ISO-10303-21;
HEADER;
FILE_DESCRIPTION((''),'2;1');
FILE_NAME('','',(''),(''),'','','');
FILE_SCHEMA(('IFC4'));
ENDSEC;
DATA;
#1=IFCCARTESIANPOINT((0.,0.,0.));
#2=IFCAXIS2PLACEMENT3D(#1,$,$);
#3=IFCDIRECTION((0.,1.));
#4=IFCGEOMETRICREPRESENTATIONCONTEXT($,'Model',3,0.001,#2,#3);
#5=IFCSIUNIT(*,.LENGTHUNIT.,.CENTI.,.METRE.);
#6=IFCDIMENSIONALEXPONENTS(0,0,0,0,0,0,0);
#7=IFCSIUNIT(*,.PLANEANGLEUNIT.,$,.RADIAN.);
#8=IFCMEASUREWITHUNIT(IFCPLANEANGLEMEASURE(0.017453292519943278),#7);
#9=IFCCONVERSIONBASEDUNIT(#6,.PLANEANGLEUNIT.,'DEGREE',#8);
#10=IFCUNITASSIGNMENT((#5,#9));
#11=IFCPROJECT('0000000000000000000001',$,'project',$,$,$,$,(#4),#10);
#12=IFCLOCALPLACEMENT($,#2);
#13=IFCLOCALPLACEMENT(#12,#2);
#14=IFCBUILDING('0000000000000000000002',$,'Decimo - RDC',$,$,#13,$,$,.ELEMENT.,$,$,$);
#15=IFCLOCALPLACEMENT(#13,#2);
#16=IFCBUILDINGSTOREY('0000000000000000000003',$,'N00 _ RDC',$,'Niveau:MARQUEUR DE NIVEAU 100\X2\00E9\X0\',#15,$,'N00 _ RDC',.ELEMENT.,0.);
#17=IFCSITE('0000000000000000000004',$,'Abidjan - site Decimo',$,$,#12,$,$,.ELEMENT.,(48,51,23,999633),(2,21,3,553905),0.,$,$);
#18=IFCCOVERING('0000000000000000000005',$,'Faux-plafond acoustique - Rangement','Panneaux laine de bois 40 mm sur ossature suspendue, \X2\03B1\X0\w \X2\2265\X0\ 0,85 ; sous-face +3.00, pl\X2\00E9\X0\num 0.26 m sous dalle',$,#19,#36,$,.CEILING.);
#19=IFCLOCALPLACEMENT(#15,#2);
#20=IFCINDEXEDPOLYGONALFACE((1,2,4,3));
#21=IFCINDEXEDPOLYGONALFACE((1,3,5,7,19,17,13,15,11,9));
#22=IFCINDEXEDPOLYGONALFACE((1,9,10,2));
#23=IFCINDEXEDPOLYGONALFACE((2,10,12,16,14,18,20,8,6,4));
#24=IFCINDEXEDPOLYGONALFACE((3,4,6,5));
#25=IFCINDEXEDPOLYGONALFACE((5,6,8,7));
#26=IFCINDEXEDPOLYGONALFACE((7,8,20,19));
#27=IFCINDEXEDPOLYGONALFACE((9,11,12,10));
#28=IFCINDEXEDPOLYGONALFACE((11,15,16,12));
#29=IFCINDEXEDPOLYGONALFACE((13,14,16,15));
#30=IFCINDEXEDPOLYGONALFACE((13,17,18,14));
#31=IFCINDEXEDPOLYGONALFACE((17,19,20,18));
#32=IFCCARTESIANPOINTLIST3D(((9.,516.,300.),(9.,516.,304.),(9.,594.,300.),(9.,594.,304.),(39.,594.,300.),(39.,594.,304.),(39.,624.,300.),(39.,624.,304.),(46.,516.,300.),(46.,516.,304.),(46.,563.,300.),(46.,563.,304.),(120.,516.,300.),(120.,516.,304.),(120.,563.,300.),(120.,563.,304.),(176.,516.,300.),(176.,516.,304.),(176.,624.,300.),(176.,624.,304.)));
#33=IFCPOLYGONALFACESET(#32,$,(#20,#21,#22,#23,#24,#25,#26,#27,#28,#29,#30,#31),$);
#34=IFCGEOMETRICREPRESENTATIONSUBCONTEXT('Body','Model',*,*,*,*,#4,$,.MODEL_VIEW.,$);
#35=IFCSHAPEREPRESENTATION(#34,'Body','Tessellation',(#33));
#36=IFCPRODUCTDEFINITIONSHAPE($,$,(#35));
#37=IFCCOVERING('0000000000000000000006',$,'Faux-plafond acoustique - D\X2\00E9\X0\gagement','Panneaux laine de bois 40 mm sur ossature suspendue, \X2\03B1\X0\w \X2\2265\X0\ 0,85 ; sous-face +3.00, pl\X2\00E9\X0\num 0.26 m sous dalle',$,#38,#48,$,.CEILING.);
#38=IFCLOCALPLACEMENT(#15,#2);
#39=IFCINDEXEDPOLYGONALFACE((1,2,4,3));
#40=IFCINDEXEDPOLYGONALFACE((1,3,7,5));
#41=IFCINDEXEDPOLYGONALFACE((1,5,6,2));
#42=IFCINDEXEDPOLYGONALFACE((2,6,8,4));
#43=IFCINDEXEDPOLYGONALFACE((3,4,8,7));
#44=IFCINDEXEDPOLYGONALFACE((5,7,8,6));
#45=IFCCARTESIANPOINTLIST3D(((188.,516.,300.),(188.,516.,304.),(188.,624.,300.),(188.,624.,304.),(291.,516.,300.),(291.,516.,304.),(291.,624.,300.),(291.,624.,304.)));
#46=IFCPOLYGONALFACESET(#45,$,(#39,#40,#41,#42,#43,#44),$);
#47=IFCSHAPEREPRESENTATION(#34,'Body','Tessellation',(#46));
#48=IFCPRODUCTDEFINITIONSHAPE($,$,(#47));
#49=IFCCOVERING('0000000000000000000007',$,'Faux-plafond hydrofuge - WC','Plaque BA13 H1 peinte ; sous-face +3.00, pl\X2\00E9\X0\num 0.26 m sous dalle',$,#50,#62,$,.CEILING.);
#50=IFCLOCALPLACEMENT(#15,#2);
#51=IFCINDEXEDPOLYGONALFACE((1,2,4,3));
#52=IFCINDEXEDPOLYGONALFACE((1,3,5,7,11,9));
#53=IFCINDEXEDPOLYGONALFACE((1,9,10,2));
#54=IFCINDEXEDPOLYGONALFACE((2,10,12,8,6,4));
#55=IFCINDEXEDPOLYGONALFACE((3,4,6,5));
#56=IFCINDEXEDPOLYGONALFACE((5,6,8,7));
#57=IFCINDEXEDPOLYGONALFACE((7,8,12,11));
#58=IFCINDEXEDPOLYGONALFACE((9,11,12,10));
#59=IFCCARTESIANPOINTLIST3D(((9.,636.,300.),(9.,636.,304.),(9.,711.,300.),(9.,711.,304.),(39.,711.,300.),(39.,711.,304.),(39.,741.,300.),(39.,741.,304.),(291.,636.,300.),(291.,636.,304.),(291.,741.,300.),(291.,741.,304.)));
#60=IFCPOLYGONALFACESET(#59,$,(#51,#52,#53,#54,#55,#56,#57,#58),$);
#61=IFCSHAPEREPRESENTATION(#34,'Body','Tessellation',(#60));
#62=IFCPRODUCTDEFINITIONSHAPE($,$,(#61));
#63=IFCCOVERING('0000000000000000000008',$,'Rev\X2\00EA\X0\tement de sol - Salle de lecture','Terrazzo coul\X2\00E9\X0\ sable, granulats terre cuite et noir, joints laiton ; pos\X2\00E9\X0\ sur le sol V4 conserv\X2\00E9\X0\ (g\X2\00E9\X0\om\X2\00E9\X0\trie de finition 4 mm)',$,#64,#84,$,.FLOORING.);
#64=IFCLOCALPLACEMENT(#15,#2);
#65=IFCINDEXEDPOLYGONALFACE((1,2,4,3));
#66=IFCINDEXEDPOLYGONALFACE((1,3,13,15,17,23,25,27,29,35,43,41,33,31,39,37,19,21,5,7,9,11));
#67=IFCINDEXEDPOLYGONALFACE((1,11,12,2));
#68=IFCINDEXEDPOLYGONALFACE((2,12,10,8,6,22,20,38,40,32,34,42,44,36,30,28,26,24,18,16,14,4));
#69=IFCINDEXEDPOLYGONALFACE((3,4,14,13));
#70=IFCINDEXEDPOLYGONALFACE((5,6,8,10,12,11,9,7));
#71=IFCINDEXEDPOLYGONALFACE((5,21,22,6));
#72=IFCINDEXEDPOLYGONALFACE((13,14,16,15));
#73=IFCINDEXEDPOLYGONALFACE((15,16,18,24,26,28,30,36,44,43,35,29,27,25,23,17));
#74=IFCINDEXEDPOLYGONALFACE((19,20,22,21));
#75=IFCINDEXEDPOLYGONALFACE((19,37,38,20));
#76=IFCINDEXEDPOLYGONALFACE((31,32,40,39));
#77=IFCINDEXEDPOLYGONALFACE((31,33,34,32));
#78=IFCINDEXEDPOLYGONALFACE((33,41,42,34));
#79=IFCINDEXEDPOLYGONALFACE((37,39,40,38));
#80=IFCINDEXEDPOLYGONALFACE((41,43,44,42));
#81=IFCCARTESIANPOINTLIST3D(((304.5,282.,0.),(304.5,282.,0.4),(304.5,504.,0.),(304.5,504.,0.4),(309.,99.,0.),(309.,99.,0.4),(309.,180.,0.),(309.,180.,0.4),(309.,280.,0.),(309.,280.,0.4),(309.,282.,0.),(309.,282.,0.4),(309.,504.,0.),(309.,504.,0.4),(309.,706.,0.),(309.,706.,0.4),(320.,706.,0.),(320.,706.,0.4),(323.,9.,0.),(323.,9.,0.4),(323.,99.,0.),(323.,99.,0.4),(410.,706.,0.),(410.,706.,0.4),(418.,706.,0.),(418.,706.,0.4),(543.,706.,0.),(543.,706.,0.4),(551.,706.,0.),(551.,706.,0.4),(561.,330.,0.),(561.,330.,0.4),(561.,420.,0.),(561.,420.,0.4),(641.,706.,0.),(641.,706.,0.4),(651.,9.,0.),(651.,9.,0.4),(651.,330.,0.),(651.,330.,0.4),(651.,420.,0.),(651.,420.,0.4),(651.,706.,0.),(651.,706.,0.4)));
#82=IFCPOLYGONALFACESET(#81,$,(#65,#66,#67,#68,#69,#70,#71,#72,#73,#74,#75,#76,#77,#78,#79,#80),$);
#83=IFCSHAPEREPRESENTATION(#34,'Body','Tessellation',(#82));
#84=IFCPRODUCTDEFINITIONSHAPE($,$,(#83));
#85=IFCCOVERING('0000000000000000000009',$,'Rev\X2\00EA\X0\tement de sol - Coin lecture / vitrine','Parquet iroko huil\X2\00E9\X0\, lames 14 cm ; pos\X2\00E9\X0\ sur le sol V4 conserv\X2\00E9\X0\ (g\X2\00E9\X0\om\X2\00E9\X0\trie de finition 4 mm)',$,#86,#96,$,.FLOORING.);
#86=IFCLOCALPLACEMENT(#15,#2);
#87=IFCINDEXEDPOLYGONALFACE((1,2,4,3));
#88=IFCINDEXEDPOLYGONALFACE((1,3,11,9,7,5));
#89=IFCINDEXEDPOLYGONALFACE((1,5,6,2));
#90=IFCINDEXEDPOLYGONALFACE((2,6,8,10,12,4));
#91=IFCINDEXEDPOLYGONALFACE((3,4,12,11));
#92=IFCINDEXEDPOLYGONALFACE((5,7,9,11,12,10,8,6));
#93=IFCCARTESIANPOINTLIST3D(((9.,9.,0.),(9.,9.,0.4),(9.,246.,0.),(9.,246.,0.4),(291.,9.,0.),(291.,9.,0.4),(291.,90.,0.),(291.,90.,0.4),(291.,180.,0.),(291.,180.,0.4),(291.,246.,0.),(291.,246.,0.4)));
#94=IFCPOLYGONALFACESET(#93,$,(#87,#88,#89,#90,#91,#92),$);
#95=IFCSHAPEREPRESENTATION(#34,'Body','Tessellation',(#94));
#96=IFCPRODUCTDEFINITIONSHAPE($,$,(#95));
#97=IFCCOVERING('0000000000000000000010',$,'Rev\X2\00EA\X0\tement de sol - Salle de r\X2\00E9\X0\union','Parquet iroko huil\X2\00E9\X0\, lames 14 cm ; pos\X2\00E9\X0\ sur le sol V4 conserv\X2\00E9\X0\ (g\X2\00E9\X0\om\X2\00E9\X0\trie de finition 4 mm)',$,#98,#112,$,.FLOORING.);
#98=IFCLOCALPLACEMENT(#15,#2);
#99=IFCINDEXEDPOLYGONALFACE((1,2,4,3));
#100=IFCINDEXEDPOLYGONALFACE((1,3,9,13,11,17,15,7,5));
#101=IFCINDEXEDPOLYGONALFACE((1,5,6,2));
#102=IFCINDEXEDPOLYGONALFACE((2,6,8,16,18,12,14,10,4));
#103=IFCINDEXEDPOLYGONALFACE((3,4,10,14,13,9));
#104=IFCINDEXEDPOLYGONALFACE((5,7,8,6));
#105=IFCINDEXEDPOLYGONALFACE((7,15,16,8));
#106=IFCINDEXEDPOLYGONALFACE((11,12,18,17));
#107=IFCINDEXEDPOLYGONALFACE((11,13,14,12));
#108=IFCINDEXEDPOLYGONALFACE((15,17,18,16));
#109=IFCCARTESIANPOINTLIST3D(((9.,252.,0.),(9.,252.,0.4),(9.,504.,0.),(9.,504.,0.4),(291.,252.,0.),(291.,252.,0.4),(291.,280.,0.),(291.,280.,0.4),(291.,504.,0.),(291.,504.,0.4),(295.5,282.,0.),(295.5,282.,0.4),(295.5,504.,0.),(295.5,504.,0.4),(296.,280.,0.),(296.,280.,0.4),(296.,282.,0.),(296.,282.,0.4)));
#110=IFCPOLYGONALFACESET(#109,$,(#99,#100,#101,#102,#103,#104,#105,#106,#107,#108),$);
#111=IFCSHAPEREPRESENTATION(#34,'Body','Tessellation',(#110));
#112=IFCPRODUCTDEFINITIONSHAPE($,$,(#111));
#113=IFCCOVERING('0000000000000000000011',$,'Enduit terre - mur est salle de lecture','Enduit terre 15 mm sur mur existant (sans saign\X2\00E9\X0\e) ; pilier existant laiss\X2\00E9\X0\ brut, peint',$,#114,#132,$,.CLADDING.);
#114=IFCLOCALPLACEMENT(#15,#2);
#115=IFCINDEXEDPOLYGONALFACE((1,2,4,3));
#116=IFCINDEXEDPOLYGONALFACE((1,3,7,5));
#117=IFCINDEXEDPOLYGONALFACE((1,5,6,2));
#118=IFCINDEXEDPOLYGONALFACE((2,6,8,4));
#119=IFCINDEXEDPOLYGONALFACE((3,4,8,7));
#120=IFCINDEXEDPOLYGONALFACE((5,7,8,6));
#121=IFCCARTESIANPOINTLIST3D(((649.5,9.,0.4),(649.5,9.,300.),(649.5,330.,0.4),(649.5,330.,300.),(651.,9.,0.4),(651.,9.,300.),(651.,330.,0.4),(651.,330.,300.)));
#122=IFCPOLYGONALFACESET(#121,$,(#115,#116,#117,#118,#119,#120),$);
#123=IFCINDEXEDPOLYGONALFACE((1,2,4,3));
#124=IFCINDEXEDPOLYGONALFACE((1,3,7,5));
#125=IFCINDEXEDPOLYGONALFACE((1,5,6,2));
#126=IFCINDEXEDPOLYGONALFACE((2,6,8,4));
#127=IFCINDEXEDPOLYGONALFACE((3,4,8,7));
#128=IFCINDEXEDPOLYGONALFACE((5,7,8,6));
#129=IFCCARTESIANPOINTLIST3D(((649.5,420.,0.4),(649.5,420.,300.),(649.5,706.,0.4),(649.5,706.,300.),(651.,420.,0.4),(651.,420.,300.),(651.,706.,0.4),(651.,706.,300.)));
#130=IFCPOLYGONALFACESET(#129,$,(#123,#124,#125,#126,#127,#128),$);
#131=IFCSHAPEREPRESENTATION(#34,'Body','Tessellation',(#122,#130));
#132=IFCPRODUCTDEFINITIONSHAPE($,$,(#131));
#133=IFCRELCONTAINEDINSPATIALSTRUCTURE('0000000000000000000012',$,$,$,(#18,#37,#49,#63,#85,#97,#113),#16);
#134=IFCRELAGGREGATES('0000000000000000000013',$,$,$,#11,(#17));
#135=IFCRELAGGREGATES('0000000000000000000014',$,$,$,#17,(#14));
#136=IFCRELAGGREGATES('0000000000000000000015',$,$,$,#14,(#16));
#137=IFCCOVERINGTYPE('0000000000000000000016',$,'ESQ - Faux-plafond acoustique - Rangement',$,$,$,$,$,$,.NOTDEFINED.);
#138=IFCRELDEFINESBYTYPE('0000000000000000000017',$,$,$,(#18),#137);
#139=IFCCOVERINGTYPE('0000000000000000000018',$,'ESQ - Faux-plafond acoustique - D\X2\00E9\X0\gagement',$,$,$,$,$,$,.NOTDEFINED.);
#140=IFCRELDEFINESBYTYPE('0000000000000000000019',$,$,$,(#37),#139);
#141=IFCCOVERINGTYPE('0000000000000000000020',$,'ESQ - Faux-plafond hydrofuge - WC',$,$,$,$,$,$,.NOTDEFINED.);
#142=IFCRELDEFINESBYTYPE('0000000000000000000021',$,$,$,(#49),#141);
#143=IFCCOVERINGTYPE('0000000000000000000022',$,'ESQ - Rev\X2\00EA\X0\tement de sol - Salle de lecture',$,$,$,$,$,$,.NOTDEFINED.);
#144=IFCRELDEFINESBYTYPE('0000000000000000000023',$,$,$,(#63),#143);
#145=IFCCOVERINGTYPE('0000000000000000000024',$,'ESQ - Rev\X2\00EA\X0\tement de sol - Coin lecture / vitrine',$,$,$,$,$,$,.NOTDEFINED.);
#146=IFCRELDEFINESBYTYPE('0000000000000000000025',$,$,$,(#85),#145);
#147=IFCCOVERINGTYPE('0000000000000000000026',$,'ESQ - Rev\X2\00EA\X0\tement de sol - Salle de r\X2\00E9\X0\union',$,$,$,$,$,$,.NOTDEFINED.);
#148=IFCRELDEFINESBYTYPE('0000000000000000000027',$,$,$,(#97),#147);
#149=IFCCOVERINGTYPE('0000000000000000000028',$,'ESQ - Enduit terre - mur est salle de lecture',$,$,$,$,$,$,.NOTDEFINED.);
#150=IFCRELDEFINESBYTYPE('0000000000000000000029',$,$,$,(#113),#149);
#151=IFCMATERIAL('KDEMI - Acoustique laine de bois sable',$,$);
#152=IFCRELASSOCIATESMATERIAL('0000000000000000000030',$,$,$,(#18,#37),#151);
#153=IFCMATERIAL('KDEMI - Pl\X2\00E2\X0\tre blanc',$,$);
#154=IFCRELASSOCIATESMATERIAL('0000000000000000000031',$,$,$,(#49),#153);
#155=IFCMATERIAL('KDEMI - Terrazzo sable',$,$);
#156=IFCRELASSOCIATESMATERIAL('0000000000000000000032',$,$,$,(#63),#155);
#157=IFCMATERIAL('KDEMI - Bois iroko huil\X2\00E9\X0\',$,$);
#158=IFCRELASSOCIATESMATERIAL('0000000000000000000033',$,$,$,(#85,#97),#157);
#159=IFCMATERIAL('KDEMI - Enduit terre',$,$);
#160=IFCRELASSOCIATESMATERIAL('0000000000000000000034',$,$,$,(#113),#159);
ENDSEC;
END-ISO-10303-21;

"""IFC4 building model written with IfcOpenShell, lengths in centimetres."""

from ifc_helpers import new_model, entity, si_unit, converted_unit, direction, frame, frame_2d, origin, origin_with_axes, place, context, subcontext, project, spatial, polyline, rectangle, outline, extrude, material, type_object, element, save


model = new_model("IFC4")

# Units and contexts
model_context = context("Model", 3, precision=0.001, world=origin(), true_north=direction((0.0, 1.0)))
body_context = subcontext(model_context, "Body", "Model", "MODEL_VIEW")
ifc_project = project(units=[si_unit("LENGTHUNIT", "METRE", prefix="CENTI"), converted_unit("PLANEANGLEUNIT", "DEGREE", entity("IfcPlaneAngleMeasure", 0.017453292519943278), si_unit("PLANEANGLEUNIT", "RADIAN"), dimensions=[0, 0, 0, 0, 0, 0, 0])], contexts=[model_context])

# Site, building, storey
site_placement = place(None, origin())
site = spatial("IfcSite", under=ifc_project, at=site_placement, Name="Abidjan - site Decimo", CompositionType="ELEMENT", RefLatitude=(48, 51, 23, 999633), RefLongitude=(2, 21, 3, 553905), RefElevation=0.0)
building_placement = place(site_placement, origin())
building = spatial("IfcBuilding", under=site, at=building_placement, Name="Decimo - RDC", CompositionType="ELEMENT")
storey_placement = place(building_placement, origin())
storey = spatial("IfcBuildingStorey", under=building, at=storey_placement, Name="N00 _ RDC", ObjectType="Niveau:MARQUEUR DE NIVEAU 100é", LongName="N00 _ RDC", CompositionType="ELEMENT", Elevation=0.0)

# Shared definitions
ifc_material_1 = material(Name="KDEMI - Plâtre blanc")

# Shared definitions
ifc_material_2 = material(Name="KDEMI - Bois iroko huilé")

# Coverings
ifc_material_3 = material(Name="KDEMI - Acoustique laine de bois sable")
covering_type_1 = type_object("IfcCoveringType", Name="ESQ - Faux-plafond acoustique - Rangement", PredefinedType="NOTDEFINED")
covering_1_placement = place(storey_placement, origin_with_axes())
element("IfcCovering", 1, at=covering_1_placement, inside=storey, type_object=covering_type_1, material=ifc_material_3, Name="Faux-plafond acoustique - Rangement", Description="Panneaux laine de bois 40 mm sur ossature suspendue, αw ≥ 0,85 ; sous-face +3.00, plénum 0.26 m sous dalle", PredefinedType="CEILING", context=body_context, shape_type="SweptSolid", body=[
    extrude(outline(polyline([(120.0, 563.0), (46.0, 563.0), (46.0, 516.0), (9.0, 516.0), (9.0, 594.0), (39.0, 594.0), (39.0, 624.0), (176.0, 624.0), (176.0, 516.0), (120.0, 516.0), (120.0, 563.0)])), frame((0.0, 0.0, 300.0)), (0.0, 0.0, 1.0), 4.0),
])
covering_type_2 = type_object("IfcCoveringType", Name="ESQ - Faux-plafond acoustique - Dégagement", PredefinedType="NOTDEFINED")
covering_2_placement = place(storey_placement, origin_with_axes())
element("IfcCovering", 2, at=covering_2_placement, inside=storey, type_object=covering_type_2, material=ifc_material_3, Name="Faux-plafond acoustique - Dégagement", Description="Panneaux laine de bois 40 mm sur ossature suspendue, αw ≥ 0,85 ; sous-face +3.00, plénum 0.26 m sous dalle", PredefinedType="CEILING", context=body_context, shape_type="SweptSolid", body=[
    extrude(outline(polyline([(291.0, 516.0), (188.0, 516.0), (188.0, 624.0), (291.0, 624.0), (291.0, 516.0)])), frame((0.0, 0.0, 300.0)), (0.0, 0.0, 1.0), 4.0),
])
covering_type_3 = type_object("IfcCoveringType", Name="ESQ - Faux-plafond hydrofuge - WC", PredefinedType="NOTDEFINED")
covering_3_placement = place(storey_placement, origin_with_axes())
element("IfcCovering", 3, at=covering_3_placement, inside=storey, type_object=covering_type_3, material=ifc_material_1, Name="Faux-plafond hydrofuge - WC", Description="Plaque BA13 H1 peinte ; sous-face +3.00, plénum 0.26 m sous dalle", PredefinedType="CEILING", context=body_context, shape_type="SweptSolid", body=[
    extrude(outline(polyline([(9.0, 636.0), (9.0, 711.0), (39.0, 711.0), (39.0, 741.0), (291.0, 741.0), (291.0, 636.0), (9.0, 636.0)])), frame((0.0, 0.0, 300.0)), (0.0, 0.0, 1.0), 4.0),
])
ifc_material_4 = material(Name="KDEMI - Terrazzo sable")
covering_type_4 = type_object("IfcCoveringType", Name="ESQ - Revêtement de sol - Salle de lecture", PredefinedType="NOTDEFINED")
covering_4_placement = place(storey_placement, origin_with_axes())
element("IfcCovering", 4, at=covering_4_placement, inside=storey, type_object=covering_type_4, material=ifc_material_4, Name="Revêtement de sol - Salle de lecture", Description="Terrazzo coulé sable, granulats terre cuite et noir, joints laiton ; posé sur le sol V4 conservé (géométrie de finition 4 mm)", PredefinedType="FLOORING", context=body_context, shape_type="SweptSolid", body=[
    extrude(outline(polyline([(418.0, 706.0), (543.0, 706.0), (551.0, 706.0), (641.0, 706.0), (651.0, 706.0), (651.0, 420.0), (561.0, 420.0), (561.0, 330.0), (651.0, 330.0), (651.0, 9.0), (651.0, 9.0), (651.0, 9.0), (323.0, 9.0), (323.0, 99.0), (309.0, 99.0), (309.0, 180.0), (309.0, 180.0), (309.0, 280.0), (309.0, 280.0), (309.0, 282.0), (304.0, 282.0), (304.0, 282.0), (304.5, 282.0), (304.5, 504.0), (309.0, 504.0), (309.0, 504.0), (309.0, 706.0), (320.0, 706.0), (410.0, 706.0), (418.0, 706.0)])), origin(), (0.0, 0.0, 1.0), 0.4),
])
covering_type_5 = type_object("IfcCoveringType", Name="ESQ - Revêtement de sol - Coin lecture / vitrine", PredefinedType="NOTDEFINED")
covering_5_placement = place(storey_placement, origin_with_axes())
element("IfcCovering", 5, at=covering_5_placement, inside=storey, type_object=covering_type_5, material=ifc_material_2, Name="Revêtement de sol - Coin lecture / vitrine", Description="Parquet iroko huilé, lames 14 cm ; posé sur le sol V4 conservé (géométrie de finition 4 mm)", PredefinedType="FLOORING", context=body_context, shape_type="SweptSolid", body=[
    extrude(outline(polyline([(291.0, 90.0), (291.0, 90.0), (291.0, 9.0), (9.0, 9.0), (9.0, 246.0), (291.0, 246.0), (291.0, 180.0), (291.0, 180.0), (291.0, 90.0)])), origin(), (0.0, 0.0, 1.0), 0.4),
])
covering_type_6 = type_object("IfcCoveringType", Name="ESQ - Revêtement de sol - Salle de réunion", PredefinedType="NOTDEFINED")
covering_6_placement = place(storey_placement, origin_with_axes())
element("IfcCovering", 6, at=covering_6_placement, inside=storey, type_object=covering_type_6, material=ifc_material_2, Name="Revêtement de sol - Salle de réunion", Description="Parquet iroko huilé, lames 14 cm ; posé sur le sol V4 conservé (géométrie de finition 4 mm)", PredefinedType="FLOORING", context=body_context, shape_type="SweptSolid", body=[
    extrude(outline(polyline([(296.0, 280.0), (291.0, 280.0), (291.0, 252.0), (9.0, 252.0), (9.0, 504.0), (291.0, 504.0), (295.5, 504.0), (295.5, 282.0), (296.0, 282.0), (296.0, 280.0)])), origin(), (0.0, 0.0, 1.0), 0.4),
])
ifc_material_5 = material(Name="KDEMI - Enduit terre")
covering_type_7 = type_object("IfcCoveringType", Name="ESQ - Enduit terre - mur est salle de lecture", PredefinedType="NOTDEFINED")
covering_7_placement = place(storey_placement, origin_with_axes())
element("IfcCovering", 7, at=covering_7_placement, inside=storey, type_object=covering_type_7, material=ifc_material_5, Name="Enduit terre - mur est salle de lecture", Description="Enduit terre 15 mm sur mur existant (sans saignée) ; pilier existant laissé brut, peint", PredefinedType="CLADDING", context=body_context, shape_type="SweptSolid", body=[
    extrude(rectangle(XDim=1.5, YDim=321.0, at=frame_2d((650.25, 169.5))), frame((0.0, 0.0, 0.4)), (0.0, 0.0, 1.0), 299.6),
    extrude(rectangle(XDim=1.5, YDim=286.0, at=frame_2d((650.25, 563.0))), frame((0.0, 0.0, 0.4)), (0.0, 0.0, 1.0), 299.6),
])

save(model, "model.ifc")
